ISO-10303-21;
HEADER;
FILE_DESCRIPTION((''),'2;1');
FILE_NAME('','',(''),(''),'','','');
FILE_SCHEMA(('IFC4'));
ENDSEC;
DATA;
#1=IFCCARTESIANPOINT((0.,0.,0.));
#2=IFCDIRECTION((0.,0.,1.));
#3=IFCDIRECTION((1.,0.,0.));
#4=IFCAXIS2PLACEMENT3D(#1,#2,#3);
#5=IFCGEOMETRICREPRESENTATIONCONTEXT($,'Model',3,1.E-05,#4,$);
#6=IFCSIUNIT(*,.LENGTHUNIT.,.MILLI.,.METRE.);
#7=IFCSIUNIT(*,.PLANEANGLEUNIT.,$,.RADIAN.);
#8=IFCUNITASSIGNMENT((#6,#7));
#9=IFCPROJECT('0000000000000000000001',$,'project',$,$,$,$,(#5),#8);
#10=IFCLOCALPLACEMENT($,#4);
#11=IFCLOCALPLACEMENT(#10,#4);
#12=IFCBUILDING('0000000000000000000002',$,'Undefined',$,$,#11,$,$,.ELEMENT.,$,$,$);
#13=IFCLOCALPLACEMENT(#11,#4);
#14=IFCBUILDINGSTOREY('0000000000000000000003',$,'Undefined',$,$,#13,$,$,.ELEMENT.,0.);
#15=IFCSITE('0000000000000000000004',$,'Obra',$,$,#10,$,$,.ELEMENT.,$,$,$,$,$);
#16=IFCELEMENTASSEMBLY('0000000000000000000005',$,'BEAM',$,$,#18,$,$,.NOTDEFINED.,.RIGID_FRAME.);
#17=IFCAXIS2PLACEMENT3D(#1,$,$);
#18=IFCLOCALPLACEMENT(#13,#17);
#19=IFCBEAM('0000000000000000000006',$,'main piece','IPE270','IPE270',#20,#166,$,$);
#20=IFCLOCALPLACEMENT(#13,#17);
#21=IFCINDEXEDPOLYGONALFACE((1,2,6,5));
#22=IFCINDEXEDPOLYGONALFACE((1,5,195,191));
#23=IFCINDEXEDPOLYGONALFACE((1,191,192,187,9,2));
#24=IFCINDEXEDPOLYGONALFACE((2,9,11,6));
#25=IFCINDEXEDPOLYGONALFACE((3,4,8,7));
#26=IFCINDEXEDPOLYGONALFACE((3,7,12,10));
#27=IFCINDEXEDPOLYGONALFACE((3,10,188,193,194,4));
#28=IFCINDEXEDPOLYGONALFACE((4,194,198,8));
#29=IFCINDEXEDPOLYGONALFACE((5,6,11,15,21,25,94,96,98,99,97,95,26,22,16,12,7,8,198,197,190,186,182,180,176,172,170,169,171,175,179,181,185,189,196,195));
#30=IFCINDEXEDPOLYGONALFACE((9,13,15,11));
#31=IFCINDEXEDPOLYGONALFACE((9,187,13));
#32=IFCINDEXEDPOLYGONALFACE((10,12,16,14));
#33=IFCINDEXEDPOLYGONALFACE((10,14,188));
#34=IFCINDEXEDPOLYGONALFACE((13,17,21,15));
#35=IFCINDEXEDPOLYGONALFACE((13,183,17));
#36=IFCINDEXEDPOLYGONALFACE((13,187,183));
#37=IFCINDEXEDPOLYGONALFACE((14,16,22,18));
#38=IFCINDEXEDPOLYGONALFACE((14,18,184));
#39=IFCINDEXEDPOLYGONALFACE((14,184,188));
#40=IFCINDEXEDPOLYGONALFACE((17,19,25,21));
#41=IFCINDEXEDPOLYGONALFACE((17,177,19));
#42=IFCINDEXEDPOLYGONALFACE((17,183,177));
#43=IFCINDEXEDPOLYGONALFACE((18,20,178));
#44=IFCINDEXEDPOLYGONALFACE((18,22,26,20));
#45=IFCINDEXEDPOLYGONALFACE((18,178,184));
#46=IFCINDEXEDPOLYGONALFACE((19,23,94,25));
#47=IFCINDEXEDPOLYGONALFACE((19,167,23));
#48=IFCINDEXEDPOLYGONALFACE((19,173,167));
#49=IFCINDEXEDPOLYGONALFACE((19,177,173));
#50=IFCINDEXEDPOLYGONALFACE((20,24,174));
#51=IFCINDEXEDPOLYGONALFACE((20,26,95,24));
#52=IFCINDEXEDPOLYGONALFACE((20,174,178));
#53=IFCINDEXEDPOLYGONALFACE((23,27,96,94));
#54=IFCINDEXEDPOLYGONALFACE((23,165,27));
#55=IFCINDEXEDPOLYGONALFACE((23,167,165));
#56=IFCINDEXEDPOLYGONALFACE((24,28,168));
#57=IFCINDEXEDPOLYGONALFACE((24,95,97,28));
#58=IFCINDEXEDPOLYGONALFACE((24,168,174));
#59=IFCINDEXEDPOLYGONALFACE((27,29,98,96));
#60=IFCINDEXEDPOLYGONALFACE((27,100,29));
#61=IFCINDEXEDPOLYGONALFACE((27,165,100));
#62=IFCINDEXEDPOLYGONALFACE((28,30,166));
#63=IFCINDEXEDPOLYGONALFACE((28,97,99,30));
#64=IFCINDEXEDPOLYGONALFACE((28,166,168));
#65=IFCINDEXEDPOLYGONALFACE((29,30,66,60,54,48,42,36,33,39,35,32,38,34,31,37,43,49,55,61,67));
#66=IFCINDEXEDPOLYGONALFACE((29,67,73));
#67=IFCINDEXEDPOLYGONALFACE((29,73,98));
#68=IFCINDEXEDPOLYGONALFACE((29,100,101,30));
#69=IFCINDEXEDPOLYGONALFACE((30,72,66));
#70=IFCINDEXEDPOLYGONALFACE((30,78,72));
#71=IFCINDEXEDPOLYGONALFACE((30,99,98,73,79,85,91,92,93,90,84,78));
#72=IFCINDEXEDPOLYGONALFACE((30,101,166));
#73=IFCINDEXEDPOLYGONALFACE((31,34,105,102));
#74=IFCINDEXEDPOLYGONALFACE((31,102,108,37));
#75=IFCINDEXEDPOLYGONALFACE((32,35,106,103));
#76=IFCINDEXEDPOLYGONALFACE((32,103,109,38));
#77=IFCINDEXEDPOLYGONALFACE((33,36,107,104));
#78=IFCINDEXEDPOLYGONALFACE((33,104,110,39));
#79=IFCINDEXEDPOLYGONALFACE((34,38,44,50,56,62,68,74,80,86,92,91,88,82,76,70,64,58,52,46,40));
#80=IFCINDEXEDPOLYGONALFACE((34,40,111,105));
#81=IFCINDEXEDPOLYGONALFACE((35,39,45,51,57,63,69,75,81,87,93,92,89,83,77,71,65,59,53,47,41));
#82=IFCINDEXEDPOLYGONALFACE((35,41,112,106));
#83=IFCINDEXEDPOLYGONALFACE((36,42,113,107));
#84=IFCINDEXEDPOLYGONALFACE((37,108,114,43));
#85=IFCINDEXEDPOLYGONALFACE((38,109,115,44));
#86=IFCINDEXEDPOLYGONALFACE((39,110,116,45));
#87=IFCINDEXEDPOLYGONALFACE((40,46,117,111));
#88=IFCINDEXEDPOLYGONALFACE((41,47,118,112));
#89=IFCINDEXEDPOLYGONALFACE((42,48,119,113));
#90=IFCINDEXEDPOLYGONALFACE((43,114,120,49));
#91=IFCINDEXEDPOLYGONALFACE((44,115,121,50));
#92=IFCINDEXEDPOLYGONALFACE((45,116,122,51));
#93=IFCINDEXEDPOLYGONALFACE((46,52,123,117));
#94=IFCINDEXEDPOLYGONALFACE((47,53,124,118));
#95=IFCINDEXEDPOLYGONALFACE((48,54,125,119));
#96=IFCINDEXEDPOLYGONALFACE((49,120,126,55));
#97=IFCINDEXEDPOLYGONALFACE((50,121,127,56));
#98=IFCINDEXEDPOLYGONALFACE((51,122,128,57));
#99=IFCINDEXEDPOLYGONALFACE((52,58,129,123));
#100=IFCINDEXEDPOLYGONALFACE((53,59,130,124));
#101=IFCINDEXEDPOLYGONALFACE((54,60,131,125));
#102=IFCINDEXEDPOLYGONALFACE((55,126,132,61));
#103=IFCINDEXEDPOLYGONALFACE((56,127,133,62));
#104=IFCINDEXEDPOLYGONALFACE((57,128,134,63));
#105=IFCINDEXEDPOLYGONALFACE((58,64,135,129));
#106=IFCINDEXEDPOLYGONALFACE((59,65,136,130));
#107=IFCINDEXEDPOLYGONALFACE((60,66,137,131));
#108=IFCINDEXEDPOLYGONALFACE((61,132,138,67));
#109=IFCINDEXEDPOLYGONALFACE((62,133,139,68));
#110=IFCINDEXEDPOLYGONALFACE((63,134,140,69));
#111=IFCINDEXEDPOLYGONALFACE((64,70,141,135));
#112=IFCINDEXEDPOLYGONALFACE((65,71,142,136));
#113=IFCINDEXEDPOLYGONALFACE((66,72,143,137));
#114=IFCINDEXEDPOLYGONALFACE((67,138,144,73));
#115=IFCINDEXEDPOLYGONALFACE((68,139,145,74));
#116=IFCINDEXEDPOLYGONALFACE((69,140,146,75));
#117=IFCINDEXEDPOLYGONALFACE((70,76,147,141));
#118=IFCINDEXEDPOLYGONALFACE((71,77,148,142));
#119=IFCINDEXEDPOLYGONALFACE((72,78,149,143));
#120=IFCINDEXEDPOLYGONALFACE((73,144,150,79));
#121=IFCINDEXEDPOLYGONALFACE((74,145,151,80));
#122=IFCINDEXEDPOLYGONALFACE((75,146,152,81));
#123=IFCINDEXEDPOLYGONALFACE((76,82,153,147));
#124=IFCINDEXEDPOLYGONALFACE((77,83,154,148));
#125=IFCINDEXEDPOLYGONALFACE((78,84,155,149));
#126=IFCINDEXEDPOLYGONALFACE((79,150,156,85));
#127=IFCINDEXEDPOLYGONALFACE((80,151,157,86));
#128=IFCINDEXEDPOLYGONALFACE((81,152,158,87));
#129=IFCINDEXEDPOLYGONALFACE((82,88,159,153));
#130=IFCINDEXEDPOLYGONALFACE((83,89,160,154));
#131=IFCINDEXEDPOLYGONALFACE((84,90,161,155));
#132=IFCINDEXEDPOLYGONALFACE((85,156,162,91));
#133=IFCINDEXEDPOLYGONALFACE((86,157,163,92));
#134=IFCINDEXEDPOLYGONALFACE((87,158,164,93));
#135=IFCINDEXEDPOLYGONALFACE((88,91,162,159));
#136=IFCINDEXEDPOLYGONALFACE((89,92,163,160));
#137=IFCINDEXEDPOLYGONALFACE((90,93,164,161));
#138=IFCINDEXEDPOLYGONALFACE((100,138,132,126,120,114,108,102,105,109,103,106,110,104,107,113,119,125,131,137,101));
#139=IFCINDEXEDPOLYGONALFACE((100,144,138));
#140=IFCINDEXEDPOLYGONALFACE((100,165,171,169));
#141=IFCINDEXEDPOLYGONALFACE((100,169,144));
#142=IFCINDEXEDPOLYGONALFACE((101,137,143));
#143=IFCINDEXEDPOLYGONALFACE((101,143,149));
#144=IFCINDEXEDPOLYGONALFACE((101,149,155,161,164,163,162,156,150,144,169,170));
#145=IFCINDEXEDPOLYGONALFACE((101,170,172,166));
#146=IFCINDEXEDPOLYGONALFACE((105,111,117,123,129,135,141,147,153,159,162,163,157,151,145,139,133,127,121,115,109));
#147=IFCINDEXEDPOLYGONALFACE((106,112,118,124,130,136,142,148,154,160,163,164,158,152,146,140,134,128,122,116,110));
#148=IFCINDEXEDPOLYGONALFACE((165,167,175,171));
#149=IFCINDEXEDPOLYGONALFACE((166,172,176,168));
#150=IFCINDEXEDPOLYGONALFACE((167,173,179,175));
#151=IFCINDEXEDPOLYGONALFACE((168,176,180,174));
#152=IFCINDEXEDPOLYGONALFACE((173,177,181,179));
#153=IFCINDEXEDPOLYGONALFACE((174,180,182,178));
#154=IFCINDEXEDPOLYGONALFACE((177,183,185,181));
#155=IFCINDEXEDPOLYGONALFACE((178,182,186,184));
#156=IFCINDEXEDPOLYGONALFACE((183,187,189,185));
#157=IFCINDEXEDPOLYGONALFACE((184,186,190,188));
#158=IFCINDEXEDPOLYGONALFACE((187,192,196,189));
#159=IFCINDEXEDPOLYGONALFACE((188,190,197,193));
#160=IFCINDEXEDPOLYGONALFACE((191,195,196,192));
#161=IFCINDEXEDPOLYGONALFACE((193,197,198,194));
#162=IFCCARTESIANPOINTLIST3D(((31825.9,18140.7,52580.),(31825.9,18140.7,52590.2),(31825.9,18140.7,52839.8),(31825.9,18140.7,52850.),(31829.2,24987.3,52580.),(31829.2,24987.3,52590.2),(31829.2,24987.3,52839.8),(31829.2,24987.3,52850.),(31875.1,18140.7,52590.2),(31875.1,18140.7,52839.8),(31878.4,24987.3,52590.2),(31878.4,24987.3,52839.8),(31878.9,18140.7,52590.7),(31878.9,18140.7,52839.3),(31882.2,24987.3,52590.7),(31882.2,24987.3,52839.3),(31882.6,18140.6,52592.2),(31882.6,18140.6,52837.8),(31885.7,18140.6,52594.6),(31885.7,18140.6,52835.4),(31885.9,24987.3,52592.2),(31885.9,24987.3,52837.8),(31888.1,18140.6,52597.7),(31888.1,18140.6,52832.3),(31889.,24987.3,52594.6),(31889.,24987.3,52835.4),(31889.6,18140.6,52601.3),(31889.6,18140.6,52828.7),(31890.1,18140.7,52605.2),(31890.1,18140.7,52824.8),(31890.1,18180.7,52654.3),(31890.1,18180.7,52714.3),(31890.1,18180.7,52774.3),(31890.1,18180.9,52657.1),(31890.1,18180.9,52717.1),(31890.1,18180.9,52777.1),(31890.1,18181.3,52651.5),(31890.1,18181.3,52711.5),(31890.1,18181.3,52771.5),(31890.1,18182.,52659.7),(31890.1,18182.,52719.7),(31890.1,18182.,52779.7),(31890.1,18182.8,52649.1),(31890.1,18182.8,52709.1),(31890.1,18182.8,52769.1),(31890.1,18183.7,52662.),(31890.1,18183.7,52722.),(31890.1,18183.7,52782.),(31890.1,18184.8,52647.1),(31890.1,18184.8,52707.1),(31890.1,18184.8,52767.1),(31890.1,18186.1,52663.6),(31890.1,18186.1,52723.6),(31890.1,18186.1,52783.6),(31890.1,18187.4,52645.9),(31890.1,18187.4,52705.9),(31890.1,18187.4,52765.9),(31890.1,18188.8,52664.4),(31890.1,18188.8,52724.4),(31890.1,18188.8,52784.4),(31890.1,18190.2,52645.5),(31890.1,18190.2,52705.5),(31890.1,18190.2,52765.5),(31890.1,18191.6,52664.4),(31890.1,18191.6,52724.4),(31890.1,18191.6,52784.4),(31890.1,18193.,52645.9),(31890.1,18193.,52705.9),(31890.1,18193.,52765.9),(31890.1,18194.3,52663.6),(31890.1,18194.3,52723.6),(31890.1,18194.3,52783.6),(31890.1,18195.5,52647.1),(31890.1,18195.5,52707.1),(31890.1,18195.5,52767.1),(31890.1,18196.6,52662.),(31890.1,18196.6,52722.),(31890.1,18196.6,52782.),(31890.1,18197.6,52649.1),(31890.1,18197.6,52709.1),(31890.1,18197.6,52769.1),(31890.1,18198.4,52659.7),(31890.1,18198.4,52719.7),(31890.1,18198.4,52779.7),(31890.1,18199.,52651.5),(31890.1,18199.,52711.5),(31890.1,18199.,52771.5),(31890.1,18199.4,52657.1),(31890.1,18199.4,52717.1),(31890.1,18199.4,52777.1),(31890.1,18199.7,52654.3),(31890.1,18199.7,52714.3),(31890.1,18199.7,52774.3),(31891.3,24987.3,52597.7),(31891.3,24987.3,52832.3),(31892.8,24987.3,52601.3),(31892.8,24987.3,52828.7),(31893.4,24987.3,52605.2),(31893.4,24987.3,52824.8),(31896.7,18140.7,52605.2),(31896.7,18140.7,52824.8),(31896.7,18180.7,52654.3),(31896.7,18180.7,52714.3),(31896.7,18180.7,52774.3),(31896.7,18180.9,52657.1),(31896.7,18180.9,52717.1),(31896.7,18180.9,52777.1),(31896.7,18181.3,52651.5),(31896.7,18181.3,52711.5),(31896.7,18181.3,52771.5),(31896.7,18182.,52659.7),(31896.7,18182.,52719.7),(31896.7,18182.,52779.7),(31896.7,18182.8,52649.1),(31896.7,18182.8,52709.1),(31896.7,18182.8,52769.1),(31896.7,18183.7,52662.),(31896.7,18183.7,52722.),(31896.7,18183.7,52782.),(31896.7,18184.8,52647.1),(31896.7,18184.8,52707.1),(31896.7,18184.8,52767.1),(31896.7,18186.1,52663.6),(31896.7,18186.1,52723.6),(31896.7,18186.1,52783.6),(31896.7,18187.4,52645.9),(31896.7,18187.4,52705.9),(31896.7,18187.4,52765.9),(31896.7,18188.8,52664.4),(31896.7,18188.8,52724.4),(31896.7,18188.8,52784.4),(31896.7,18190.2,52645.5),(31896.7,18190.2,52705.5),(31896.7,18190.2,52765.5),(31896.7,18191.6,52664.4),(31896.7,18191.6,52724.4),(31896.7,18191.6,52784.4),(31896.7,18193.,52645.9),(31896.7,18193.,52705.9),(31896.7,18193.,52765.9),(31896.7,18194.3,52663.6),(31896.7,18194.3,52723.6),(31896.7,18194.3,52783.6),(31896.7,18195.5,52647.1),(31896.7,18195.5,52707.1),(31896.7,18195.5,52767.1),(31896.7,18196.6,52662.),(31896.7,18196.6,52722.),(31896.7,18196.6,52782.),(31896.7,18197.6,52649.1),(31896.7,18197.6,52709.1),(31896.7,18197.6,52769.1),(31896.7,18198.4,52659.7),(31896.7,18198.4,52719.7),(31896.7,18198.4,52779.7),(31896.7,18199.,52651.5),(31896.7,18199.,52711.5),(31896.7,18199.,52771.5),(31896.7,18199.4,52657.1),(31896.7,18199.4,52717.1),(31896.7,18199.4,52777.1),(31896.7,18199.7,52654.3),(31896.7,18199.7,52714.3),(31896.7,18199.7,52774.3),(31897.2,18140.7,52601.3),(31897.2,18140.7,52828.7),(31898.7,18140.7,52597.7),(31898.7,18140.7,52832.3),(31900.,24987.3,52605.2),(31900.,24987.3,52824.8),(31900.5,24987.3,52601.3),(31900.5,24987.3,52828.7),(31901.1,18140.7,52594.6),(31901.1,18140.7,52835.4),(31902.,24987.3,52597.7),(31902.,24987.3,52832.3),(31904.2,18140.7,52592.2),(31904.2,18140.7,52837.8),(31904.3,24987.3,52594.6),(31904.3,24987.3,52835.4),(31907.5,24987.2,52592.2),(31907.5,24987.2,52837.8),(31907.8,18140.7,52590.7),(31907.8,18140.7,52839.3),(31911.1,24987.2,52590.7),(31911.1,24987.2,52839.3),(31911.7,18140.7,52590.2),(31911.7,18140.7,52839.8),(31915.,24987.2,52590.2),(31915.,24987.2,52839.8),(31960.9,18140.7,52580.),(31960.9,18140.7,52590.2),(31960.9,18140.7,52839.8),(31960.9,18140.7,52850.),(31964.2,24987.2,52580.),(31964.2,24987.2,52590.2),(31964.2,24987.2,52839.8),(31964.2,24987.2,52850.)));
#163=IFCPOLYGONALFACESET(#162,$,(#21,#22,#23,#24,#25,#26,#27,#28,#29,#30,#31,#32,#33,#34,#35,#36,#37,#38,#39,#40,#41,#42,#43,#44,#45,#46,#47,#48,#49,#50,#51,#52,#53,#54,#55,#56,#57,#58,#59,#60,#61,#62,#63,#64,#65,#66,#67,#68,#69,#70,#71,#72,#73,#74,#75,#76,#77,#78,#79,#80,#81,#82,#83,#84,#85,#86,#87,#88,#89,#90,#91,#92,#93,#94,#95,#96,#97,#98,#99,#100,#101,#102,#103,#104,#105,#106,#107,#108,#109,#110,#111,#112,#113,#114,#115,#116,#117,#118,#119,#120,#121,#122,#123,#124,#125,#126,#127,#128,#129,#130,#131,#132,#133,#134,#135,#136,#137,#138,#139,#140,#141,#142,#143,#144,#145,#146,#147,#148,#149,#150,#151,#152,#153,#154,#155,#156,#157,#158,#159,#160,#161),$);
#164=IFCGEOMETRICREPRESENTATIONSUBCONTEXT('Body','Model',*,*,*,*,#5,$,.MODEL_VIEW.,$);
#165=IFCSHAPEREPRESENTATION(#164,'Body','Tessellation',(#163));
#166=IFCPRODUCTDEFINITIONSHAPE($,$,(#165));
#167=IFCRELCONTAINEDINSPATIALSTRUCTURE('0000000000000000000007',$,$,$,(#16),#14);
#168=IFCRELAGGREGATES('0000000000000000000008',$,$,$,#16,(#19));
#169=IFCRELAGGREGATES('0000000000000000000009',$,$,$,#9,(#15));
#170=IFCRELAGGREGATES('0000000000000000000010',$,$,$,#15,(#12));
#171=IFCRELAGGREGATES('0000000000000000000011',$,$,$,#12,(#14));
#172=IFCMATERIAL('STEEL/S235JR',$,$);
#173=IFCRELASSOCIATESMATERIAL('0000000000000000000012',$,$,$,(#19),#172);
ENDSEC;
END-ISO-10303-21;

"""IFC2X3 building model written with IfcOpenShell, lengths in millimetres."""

from ifc_helpers import new_model, si_unit, frame, origin_with_axes, origin_2d_with_axis, place, context, subcontext, project, spatial, circle, i_section, extrude, clip, halfspace, source, transform, mapped, material, element, aggregate, save


model = new_model("IFC2X3")

# Units and contexts
model_context = context("Model", 3, precision=1e-05, world=origin_with_axes())
body_context = subcontext(model_context, "Body", "Model", "MODEL_VIEW")
ifc_project = project(units=[si_unit("LENGTHUNIT", "METRE", prefix="MILLI"), si_unit("PLANEANGLEUNIT", "RADIAN")], contexts=[model_context])

# Site, building, storey
site_placement = place(None, origin_with_axes())
site = spatial("IfcSite", under=ifc_project, at=site_placement, Name="Obra", CompositionType="ELEMENT")
building_placement = place(site_placement, origin_with_axes())
building = spatial("IfcBuilding", under=site, at=building_placement, Name="Undefined", CompositionType="ELEMENT")
storey_placement = place(building_placement, origin_with_axes())
storey = spatial("IfcBuildingStorey", under=building, at=storey_placement, Name="Undefined", CompositionType="ELEMENT", Elevation=0.0)

# Shared definitions
ifc_material_1 = material(Name="STEEL/S235JR")

# Element assembly, beam, opening
assembly_1_placement = place(storey_placement, origin_with_axes())
assembly_1 = element("IfcElementAssembly", 1, at=assembly_1_placement, inside=storey, Name="BEAM", AssemblyPlace="NOTDEFINED", PredefinedType="RIGID_FRAME")
beam_1_placement = place(assembly_1_placement, frame((31893.4, 18130.2, 52715.0), z_axis=(0.0, 0.0, 1.0), x_axis=(0.00048, 1.0, 0.0)))
beam_1 = element("IfcBeam", 2, at=beam_1_placement, material=ifc_material_1, Name="main piece", Description="IPE270", ObjectType="IPE270", context=body_context, shape_type="Clipping", body=[
    clip(extrude(i_section(OverallWidth=135.0, OverallDepth=270.0, WebThickness=6.6, FlangeThickness=10.2, FilletRadius=15.0, at=origin_2d_with_axis()), frame((6857.1, 0.0, 0.0), z_axis=(-1.0, 0.0, 0.0), x_axis=(0.0, -1.0, 0.0)), (0.0, 0.0, 1.0), 6857.1), halfspace(frame((10.4, 60.3, -120.0), z_axis=(-1.0, -0.0005, 0.0), x_axis=(0.0, 0.0, 1.0)), False)),
])
shared_shape_1 = source(origin_with_axes(), body_context, "Body", "SweptSolid", [
    extrude(circle(Radius=9.5, at=origin_2d_with_axis()), frame((0.0, -3.7, 0.0), z_axis=(0.0, 1.0, 0.0), x_axis=(1.0, 0.0, 0.0)), (0.0, 0.0, 1.0), 6.8),
])
opening_1_placement = place(assembly_1_placement, frame((31893.1, 18140.2, 52835.0), z_axis=(-0.000002, 1.0, 0.0), x_axis=(0.0, 0.0, -1.0)))
element("IfcOpeningElement", 3, at=opening_1_placement, cuts=beam_1, ObjectType="Opening", context=body_context, shape_type="MappedRepresentation", body=[
    mapped(shared_shape_1, transform((60.0, 0.0, 50.0))),
    mapped(shared_shape_1, transform((120.0, 0.0, 50.0))),
    mapped(shared_shape_1, transform((180.0, 0.0, 50.0))),
])

aggregate(assembly_1, [beam_1])

save(model, "model.ifc")
